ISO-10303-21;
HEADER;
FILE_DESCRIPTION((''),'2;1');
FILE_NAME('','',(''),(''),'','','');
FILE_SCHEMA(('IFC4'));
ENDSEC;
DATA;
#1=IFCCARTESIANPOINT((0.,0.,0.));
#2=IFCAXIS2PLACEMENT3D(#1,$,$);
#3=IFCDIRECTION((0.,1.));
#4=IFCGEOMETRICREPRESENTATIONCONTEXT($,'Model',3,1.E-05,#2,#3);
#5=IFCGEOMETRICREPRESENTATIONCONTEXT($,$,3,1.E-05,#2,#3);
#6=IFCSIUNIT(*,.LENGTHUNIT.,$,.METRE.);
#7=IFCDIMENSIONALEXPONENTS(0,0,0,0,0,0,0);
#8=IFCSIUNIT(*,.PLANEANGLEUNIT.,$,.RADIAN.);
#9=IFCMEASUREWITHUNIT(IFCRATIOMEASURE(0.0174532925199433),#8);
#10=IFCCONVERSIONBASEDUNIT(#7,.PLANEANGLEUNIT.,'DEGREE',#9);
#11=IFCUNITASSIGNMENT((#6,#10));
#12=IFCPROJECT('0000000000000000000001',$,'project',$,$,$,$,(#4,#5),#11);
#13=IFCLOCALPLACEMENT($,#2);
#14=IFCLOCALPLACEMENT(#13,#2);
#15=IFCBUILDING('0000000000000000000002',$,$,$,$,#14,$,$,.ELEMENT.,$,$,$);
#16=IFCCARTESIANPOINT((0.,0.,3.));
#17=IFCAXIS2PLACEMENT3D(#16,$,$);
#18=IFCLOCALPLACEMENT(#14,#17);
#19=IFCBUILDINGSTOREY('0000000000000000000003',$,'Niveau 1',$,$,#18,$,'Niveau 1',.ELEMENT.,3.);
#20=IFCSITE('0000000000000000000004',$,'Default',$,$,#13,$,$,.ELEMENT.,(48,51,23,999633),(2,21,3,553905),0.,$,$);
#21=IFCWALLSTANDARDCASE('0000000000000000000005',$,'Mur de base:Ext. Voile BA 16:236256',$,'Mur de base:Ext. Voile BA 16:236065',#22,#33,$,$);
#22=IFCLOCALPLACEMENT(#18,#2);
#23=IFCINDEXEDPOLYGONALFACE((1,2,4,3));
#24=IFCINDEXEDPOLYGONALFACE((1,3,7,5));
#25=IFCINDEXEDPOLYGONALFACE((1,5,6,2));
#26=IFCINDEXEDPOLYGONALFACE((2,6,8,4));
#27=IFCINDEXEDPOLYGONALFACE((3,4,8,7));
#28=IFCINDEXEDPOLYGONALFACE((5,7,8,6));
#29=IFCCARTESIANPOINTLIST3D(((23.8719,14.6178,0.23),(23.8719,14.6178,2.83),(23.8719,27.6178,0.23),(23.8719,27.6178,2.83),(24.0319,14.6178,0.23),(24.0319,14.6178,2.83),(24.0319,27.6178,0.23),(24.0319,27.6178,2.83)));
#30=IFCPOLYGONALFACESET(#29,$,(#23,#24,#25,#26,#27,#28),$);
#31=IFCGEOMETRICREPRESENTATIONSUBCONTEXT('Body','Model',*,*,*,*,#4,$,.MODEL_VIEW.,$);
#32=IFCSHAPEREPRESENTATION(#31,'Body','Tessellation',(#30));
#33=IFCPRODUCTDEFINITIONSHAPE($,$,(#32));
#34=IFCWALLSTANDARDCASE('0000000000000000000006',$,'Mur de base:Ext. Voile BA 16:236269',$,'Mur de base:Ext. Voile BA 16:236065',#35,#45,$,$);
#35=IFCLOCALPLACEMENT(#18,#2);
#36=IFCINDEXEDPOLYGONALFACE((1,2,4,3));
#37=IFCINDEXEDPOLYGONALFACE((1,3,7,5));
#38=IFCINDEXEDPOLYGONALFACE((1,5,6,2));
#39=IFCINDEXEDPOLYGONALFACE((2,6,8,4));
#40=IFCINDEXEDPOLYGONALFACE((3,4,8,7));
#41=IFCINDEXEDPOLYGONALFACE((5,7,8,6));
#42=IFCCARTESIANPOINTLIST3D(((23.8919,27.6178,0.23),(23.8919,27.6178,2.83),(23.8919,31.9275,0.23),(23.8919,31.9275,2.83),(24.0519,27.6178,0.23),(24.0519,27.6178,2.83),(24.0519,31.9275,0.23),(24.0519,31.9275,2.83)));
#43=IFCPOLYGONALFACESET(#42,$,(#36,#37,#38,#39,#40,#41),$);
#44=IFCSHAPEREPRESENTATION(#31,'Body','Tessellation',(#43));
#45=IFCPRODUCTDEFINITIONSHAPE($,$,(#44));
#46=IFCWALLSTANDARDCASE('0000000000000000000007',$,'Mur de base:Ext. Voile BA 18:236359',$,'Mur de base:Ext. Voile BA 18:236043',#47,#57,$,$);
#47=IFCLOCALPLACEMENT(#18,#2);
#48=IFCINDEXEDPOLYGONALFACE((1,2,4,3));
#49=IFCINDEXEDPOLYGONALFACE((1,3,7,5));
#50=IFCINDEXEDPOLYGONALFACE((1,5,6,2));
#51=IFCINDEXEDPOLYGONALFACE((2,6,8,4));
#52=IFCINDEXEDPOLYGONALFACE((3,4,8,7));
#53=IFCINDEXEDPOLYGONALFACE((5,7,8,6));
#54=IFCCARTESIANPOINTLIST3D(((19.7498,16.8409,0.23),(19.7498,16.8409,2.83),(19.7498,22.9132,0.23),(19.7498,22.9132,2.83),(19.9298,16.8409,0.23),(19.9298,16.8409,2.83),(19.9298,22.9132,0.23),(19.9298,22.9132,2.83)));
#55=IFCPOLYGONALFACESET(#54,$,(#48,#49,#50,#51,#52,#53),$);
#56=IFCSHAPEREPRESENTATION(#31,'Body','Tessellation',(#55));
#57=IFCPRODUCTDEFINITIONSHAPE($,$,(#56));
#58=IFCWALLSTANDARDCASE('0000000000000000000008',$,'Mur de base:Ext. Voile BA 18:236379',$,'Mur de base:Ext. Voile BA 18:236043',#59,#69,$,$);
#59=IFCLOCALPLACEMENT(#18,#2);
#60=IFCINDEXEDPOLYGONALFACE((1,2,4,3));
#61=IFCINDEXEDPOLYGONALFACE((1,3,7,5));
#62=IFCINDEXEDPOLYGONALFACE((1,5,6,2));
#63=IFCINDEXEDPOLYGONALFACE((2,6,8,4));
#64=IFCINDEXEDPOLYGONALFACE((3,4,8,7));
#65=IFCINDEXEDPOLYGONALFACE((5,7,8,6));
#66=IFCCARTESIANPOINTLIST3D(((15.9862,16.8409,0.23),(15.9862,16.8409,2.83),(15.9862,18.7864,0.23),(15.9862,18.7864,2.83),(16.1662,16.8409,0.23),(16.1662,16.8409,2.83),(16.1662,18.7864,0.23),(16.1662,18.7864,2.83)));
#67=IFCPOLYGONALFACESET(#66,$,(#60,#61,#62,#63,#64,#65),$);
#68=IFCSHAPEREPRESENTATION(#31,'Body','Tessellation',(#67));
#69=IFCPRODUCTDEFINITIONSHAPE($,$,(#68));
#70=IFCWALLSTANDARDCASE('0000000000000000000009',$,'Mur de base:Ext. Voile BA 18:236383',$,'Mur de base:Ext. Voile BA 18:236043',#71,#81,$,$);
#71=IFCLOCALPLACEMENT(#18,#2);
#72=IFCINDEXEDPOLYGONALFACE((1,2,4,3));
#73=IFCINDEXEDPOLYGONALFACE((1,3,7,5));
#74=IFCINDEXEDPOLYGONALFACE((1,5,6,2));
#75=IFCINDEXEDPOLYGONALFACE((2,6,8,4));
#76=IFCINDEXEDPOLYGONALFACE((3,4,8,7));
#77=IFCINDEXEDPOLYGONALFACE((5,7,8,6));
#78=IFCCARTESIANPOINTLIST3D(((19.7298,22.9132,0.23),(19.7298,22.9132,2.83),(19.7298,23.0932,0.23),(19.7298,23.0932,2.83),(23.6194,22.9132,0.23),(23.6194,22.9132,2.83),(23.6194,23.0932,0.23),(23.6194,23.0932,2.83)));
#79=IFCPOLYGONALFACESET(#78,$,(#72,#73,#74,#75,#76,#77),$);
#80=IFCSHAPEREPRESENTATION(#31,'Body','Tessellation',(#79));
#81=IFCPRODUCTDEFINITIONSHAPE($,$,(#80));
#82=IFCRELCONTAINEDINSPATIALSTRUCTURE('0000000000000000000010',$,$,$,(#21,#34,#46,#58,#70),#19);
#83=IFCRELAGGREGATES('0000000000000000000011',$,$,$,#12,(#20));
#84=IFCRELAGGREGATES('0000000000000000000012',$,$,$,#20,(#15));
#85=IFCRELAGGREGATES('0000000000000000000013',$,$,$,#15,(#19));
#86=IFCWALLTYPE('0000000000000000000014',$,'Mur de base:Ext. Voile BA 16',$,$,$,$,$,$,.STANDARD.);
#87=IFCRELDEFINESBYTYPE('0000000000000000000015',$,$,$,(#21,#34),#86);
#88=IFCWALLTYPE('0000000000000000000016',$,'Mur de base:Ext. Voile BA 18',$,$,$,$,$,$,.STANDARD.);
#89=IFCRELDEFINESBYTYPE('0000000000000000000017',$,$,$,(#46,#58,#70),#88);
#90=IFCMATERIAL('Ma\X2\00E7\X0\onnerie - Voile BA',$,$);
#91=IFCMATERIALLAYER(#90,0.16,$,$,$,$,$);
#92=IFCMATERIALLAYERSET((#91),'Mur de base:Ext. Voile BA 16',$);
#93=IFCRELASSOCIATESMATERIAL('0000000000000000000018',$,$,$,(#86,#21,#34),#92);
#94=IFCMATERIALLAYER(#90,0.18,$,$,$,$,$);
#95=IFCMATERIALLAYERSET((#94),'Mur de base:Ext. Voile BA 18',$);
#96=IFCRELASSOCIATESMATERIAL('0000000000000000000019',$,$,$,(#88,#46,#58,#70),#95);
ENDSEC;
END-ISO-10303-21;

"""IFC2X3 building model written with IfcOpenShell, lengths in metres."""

from ifc_helpers import new_model, entity, si_unit, converted_unit, direction, frame, frame_2d, origin, place, context, subcontext, project, spatial, rectangle, extrude, material, layer, layer_set, layer_usage, type_object, element, save


model = new_model("IFC2X3")

# Units and contexts
model_context = context("Model", 3, precision=1e-05, world=origin(), true_north=direction((0.0, 1.0)))
context_of_model = context(None, 3, precision=1e-05, world=origin(), true_north=direction((0.0, 1.0)))
body_context = subcontext(model_context, "Body", "Model", "MODEL_VIEW")
ifc_project = project(units=[si_unit("LENGTHUNIT", "METRE"), converted_unit("PLANEANGLEUNIT", "DEGREE", entity("IfcRatioMeasure", 0.0174532925199433), si_unit("PLANEANGLEUNIT", "RADIAN"), dimensions=[0, 0, 0, 0, 0, 0, 0])], contexts=[model_context, context_of_model])

# Site, building, storey
site_placement = place(None, origin())
site = spatial("IfcSite", under=ifc_project, at=site_placement, Name="Default", CompositionType="ELEMENT", RefLatitude=(48, 51, 23, 999633), RefLongitude=(2, 21, 3, 553905), RefElevation=0.0)
building_placement = place(site_placement, origin())
building = spatial("IfcBuilding", under=site, at=building_placement, CompositionType="ELEMENT")
storey_placement = place(building_placement, frame((0.0, 0.0, 3.0)))
storey = spatial("IfcBuildingStorey", under=building, at=storey_placement, Name="Niveau 1", LongName="Niveau 1", CompositionType="ELEMENT", Elevation=3.0)

# Shared definitions
ifc_material = material(Name="Maçonnerie - Voile BA")

# Shared definitions
ifc_layer_1 = layer(ifc_material, 0.16)
ifc_layer_set_1 = layer_set([ifc_layer_1], Name="Mur de base:Ext. Voile BA 16")
wall_type_1 = type_object("IfcWallType", Name="Mur de base:Ext. Voile BA 16", PredefinedType="STANDARD", material=ifc_layer_set_1)

# Walls
ifc_layer_usage_1 = layer_usage(ifc_layer_set_1, "AXIS2", "NEGATIVE", 0.08)
wall_1_placement = place(storey_placement, frame((23.9519, 27.6178, 0.23), z_axis=(0.0, 0.0, 1.0), x_axis=(0.0, -1.0, 0.0)))
element("IfcWallStandardCase", 1, at=wall_1_placement, inside=storey, type_object=wall_type_1, material=ifc_layer_usage_1, Name="Mur de base:Ext. Voile BA 16:236256", ObjectType="Mur de base:Ext. Voile BA 16:236065", context=body_context, shape_type="SweptSolid", body=[
    extrude(rectangle(XDim=13.0, YDim=0.16, at=frame_2d((6.5, 0.0), x_axis=(-1.0, 0.0))), origin(), (0.0, 0.0, 1.0), 2.6),
])
ifc_layer_usage_2 = layer_usage(ifc_layer_set_1, "AXIS2", "NEGATIVE", 0.08)
wall_2_placement = place(storey_placement, frame((23.9719, 27.6178, 0.23), z_axis=(0.0, 0.0, 1.0), x_axis=(0.0, 1.0, 0.0)))
element("IfcWallStandardCase", 2, at=wall_2_placement, inside=storey, type_object=wall_type_1, material=ifc_layer_usage_2, Name="Mur de base:Ext. Voile BA 16:236269", ObjectType="Mur de base:Ext. Voile BA 16:236065", context=body_context, shape_type="SweptSolid", body=[
    extrude(rectangle(XDim=4.3097, YDim=0.16, at=frame_2d((2.1548, 0.0), x_axis=(-1.0, 0.0))), origin(), (0.0, 0.0, 1.0), 2.6),
])
ifc_layer_2 = layer(ifc_material, 0.18)
ifc_layer_set_2 = layer_set([ifc_layer_2], Name="Mur de base:Ext. Voile BA 18")
ifc_layer_usage_3 = layer_usage(ifc_layer_set_2, "AXIS2", "NEGATIVE", 0.09)
wall_type_2 = type_object("IfcWallType", Name="Mur de base:Ext. Voile BA 18", PredefinedType="STANDARD", material=ifc_layer_set_2)
wall_3_placement = place(storey_placement, frame((19.8398, 16.8409, 0.23), z_axis=(0.0, 0.0, 1.0), x_axis=(0.0, 1.0, 0.0)))
element("IfcWallStandardCase", 3, at=wall_3_placement, inside=storey, type_object=wall_type_2, material=ifc_layer_usage_3, Name="Mur de base:Ext. Voile BA 18:236359", ObjectType="Mur de base:Ext. Voile BA 18:236043", context=body_context, shape_type="SweptSolid", body=[
    extrude(rectangle(XDim=6.0722, YDim=0.18, at=frame_2d((3.0361, 0.0), x_axis=(-1.0, 0.0))), origin(), (0.0, 0.0, 1.0), 2.6),
])
ifc_layer_usage_4 = layer_usage(ifc_layer_set_2, "AXIS2", "NEGATIVE", 0.09)
wall_4_placement = place(storey_placement, frame((16.0762, 18.7864, 0.23), z_axis=(0.0, 0.0, 1.0), x_axis=(0.0, -1.0, 0.0)))
element("IfcWallStandardCase", 4, at=wall_4_placement, inside=storey, type_object=wall_type_2, material=ifc_layer_usage_4, Name="Mur de base:Ext. Voile BA 18:236379", ObjectType="Mur de base:Ext. Voile BA 18:236043", context=body_context, shape_type="SweptSolid", body=[
    extrude(rectangle(XDim=1.9455, YDim=0.18, at=frame_2d((0.9727, 0.0), x_axis=(-1.0, 0.0))), origin(), (0.0, 0.0, 1.0), 2.6),
])
ifc_layer_usage_5 = layer_usage(ifc_layer_set_2, "AXIS2", "NEGATIVE", 0.09)
wall_5_placement = place(storey_placement, frame((23.6194, 23.0032, 0.23), z_axis=(0.0, 0.0, 1.0), x_axis=(-1.0, 0.0, 0.0)))
element("IfcWallStandardCase", 5, at=wall_5_placement, inside=storey, type_object=wall_type_2, material=ifc_layer_usage_5, Name="Mur de base:Ext. Voile BA 18:236383", ObjectType="Mur de base:Ext. Voile BA 18:236043", context=body_context, shape_type="SweptSolid", body=[
    extrude(rectangle(XDim=3.8895, YDim=0.18, at=frame_2d((1.9448, 0.0), x_axis=(-1.0, 0.0))), origin(), (0.0, 0.0, 1.0), 2.6),
])

save(model, "model.ifc")
